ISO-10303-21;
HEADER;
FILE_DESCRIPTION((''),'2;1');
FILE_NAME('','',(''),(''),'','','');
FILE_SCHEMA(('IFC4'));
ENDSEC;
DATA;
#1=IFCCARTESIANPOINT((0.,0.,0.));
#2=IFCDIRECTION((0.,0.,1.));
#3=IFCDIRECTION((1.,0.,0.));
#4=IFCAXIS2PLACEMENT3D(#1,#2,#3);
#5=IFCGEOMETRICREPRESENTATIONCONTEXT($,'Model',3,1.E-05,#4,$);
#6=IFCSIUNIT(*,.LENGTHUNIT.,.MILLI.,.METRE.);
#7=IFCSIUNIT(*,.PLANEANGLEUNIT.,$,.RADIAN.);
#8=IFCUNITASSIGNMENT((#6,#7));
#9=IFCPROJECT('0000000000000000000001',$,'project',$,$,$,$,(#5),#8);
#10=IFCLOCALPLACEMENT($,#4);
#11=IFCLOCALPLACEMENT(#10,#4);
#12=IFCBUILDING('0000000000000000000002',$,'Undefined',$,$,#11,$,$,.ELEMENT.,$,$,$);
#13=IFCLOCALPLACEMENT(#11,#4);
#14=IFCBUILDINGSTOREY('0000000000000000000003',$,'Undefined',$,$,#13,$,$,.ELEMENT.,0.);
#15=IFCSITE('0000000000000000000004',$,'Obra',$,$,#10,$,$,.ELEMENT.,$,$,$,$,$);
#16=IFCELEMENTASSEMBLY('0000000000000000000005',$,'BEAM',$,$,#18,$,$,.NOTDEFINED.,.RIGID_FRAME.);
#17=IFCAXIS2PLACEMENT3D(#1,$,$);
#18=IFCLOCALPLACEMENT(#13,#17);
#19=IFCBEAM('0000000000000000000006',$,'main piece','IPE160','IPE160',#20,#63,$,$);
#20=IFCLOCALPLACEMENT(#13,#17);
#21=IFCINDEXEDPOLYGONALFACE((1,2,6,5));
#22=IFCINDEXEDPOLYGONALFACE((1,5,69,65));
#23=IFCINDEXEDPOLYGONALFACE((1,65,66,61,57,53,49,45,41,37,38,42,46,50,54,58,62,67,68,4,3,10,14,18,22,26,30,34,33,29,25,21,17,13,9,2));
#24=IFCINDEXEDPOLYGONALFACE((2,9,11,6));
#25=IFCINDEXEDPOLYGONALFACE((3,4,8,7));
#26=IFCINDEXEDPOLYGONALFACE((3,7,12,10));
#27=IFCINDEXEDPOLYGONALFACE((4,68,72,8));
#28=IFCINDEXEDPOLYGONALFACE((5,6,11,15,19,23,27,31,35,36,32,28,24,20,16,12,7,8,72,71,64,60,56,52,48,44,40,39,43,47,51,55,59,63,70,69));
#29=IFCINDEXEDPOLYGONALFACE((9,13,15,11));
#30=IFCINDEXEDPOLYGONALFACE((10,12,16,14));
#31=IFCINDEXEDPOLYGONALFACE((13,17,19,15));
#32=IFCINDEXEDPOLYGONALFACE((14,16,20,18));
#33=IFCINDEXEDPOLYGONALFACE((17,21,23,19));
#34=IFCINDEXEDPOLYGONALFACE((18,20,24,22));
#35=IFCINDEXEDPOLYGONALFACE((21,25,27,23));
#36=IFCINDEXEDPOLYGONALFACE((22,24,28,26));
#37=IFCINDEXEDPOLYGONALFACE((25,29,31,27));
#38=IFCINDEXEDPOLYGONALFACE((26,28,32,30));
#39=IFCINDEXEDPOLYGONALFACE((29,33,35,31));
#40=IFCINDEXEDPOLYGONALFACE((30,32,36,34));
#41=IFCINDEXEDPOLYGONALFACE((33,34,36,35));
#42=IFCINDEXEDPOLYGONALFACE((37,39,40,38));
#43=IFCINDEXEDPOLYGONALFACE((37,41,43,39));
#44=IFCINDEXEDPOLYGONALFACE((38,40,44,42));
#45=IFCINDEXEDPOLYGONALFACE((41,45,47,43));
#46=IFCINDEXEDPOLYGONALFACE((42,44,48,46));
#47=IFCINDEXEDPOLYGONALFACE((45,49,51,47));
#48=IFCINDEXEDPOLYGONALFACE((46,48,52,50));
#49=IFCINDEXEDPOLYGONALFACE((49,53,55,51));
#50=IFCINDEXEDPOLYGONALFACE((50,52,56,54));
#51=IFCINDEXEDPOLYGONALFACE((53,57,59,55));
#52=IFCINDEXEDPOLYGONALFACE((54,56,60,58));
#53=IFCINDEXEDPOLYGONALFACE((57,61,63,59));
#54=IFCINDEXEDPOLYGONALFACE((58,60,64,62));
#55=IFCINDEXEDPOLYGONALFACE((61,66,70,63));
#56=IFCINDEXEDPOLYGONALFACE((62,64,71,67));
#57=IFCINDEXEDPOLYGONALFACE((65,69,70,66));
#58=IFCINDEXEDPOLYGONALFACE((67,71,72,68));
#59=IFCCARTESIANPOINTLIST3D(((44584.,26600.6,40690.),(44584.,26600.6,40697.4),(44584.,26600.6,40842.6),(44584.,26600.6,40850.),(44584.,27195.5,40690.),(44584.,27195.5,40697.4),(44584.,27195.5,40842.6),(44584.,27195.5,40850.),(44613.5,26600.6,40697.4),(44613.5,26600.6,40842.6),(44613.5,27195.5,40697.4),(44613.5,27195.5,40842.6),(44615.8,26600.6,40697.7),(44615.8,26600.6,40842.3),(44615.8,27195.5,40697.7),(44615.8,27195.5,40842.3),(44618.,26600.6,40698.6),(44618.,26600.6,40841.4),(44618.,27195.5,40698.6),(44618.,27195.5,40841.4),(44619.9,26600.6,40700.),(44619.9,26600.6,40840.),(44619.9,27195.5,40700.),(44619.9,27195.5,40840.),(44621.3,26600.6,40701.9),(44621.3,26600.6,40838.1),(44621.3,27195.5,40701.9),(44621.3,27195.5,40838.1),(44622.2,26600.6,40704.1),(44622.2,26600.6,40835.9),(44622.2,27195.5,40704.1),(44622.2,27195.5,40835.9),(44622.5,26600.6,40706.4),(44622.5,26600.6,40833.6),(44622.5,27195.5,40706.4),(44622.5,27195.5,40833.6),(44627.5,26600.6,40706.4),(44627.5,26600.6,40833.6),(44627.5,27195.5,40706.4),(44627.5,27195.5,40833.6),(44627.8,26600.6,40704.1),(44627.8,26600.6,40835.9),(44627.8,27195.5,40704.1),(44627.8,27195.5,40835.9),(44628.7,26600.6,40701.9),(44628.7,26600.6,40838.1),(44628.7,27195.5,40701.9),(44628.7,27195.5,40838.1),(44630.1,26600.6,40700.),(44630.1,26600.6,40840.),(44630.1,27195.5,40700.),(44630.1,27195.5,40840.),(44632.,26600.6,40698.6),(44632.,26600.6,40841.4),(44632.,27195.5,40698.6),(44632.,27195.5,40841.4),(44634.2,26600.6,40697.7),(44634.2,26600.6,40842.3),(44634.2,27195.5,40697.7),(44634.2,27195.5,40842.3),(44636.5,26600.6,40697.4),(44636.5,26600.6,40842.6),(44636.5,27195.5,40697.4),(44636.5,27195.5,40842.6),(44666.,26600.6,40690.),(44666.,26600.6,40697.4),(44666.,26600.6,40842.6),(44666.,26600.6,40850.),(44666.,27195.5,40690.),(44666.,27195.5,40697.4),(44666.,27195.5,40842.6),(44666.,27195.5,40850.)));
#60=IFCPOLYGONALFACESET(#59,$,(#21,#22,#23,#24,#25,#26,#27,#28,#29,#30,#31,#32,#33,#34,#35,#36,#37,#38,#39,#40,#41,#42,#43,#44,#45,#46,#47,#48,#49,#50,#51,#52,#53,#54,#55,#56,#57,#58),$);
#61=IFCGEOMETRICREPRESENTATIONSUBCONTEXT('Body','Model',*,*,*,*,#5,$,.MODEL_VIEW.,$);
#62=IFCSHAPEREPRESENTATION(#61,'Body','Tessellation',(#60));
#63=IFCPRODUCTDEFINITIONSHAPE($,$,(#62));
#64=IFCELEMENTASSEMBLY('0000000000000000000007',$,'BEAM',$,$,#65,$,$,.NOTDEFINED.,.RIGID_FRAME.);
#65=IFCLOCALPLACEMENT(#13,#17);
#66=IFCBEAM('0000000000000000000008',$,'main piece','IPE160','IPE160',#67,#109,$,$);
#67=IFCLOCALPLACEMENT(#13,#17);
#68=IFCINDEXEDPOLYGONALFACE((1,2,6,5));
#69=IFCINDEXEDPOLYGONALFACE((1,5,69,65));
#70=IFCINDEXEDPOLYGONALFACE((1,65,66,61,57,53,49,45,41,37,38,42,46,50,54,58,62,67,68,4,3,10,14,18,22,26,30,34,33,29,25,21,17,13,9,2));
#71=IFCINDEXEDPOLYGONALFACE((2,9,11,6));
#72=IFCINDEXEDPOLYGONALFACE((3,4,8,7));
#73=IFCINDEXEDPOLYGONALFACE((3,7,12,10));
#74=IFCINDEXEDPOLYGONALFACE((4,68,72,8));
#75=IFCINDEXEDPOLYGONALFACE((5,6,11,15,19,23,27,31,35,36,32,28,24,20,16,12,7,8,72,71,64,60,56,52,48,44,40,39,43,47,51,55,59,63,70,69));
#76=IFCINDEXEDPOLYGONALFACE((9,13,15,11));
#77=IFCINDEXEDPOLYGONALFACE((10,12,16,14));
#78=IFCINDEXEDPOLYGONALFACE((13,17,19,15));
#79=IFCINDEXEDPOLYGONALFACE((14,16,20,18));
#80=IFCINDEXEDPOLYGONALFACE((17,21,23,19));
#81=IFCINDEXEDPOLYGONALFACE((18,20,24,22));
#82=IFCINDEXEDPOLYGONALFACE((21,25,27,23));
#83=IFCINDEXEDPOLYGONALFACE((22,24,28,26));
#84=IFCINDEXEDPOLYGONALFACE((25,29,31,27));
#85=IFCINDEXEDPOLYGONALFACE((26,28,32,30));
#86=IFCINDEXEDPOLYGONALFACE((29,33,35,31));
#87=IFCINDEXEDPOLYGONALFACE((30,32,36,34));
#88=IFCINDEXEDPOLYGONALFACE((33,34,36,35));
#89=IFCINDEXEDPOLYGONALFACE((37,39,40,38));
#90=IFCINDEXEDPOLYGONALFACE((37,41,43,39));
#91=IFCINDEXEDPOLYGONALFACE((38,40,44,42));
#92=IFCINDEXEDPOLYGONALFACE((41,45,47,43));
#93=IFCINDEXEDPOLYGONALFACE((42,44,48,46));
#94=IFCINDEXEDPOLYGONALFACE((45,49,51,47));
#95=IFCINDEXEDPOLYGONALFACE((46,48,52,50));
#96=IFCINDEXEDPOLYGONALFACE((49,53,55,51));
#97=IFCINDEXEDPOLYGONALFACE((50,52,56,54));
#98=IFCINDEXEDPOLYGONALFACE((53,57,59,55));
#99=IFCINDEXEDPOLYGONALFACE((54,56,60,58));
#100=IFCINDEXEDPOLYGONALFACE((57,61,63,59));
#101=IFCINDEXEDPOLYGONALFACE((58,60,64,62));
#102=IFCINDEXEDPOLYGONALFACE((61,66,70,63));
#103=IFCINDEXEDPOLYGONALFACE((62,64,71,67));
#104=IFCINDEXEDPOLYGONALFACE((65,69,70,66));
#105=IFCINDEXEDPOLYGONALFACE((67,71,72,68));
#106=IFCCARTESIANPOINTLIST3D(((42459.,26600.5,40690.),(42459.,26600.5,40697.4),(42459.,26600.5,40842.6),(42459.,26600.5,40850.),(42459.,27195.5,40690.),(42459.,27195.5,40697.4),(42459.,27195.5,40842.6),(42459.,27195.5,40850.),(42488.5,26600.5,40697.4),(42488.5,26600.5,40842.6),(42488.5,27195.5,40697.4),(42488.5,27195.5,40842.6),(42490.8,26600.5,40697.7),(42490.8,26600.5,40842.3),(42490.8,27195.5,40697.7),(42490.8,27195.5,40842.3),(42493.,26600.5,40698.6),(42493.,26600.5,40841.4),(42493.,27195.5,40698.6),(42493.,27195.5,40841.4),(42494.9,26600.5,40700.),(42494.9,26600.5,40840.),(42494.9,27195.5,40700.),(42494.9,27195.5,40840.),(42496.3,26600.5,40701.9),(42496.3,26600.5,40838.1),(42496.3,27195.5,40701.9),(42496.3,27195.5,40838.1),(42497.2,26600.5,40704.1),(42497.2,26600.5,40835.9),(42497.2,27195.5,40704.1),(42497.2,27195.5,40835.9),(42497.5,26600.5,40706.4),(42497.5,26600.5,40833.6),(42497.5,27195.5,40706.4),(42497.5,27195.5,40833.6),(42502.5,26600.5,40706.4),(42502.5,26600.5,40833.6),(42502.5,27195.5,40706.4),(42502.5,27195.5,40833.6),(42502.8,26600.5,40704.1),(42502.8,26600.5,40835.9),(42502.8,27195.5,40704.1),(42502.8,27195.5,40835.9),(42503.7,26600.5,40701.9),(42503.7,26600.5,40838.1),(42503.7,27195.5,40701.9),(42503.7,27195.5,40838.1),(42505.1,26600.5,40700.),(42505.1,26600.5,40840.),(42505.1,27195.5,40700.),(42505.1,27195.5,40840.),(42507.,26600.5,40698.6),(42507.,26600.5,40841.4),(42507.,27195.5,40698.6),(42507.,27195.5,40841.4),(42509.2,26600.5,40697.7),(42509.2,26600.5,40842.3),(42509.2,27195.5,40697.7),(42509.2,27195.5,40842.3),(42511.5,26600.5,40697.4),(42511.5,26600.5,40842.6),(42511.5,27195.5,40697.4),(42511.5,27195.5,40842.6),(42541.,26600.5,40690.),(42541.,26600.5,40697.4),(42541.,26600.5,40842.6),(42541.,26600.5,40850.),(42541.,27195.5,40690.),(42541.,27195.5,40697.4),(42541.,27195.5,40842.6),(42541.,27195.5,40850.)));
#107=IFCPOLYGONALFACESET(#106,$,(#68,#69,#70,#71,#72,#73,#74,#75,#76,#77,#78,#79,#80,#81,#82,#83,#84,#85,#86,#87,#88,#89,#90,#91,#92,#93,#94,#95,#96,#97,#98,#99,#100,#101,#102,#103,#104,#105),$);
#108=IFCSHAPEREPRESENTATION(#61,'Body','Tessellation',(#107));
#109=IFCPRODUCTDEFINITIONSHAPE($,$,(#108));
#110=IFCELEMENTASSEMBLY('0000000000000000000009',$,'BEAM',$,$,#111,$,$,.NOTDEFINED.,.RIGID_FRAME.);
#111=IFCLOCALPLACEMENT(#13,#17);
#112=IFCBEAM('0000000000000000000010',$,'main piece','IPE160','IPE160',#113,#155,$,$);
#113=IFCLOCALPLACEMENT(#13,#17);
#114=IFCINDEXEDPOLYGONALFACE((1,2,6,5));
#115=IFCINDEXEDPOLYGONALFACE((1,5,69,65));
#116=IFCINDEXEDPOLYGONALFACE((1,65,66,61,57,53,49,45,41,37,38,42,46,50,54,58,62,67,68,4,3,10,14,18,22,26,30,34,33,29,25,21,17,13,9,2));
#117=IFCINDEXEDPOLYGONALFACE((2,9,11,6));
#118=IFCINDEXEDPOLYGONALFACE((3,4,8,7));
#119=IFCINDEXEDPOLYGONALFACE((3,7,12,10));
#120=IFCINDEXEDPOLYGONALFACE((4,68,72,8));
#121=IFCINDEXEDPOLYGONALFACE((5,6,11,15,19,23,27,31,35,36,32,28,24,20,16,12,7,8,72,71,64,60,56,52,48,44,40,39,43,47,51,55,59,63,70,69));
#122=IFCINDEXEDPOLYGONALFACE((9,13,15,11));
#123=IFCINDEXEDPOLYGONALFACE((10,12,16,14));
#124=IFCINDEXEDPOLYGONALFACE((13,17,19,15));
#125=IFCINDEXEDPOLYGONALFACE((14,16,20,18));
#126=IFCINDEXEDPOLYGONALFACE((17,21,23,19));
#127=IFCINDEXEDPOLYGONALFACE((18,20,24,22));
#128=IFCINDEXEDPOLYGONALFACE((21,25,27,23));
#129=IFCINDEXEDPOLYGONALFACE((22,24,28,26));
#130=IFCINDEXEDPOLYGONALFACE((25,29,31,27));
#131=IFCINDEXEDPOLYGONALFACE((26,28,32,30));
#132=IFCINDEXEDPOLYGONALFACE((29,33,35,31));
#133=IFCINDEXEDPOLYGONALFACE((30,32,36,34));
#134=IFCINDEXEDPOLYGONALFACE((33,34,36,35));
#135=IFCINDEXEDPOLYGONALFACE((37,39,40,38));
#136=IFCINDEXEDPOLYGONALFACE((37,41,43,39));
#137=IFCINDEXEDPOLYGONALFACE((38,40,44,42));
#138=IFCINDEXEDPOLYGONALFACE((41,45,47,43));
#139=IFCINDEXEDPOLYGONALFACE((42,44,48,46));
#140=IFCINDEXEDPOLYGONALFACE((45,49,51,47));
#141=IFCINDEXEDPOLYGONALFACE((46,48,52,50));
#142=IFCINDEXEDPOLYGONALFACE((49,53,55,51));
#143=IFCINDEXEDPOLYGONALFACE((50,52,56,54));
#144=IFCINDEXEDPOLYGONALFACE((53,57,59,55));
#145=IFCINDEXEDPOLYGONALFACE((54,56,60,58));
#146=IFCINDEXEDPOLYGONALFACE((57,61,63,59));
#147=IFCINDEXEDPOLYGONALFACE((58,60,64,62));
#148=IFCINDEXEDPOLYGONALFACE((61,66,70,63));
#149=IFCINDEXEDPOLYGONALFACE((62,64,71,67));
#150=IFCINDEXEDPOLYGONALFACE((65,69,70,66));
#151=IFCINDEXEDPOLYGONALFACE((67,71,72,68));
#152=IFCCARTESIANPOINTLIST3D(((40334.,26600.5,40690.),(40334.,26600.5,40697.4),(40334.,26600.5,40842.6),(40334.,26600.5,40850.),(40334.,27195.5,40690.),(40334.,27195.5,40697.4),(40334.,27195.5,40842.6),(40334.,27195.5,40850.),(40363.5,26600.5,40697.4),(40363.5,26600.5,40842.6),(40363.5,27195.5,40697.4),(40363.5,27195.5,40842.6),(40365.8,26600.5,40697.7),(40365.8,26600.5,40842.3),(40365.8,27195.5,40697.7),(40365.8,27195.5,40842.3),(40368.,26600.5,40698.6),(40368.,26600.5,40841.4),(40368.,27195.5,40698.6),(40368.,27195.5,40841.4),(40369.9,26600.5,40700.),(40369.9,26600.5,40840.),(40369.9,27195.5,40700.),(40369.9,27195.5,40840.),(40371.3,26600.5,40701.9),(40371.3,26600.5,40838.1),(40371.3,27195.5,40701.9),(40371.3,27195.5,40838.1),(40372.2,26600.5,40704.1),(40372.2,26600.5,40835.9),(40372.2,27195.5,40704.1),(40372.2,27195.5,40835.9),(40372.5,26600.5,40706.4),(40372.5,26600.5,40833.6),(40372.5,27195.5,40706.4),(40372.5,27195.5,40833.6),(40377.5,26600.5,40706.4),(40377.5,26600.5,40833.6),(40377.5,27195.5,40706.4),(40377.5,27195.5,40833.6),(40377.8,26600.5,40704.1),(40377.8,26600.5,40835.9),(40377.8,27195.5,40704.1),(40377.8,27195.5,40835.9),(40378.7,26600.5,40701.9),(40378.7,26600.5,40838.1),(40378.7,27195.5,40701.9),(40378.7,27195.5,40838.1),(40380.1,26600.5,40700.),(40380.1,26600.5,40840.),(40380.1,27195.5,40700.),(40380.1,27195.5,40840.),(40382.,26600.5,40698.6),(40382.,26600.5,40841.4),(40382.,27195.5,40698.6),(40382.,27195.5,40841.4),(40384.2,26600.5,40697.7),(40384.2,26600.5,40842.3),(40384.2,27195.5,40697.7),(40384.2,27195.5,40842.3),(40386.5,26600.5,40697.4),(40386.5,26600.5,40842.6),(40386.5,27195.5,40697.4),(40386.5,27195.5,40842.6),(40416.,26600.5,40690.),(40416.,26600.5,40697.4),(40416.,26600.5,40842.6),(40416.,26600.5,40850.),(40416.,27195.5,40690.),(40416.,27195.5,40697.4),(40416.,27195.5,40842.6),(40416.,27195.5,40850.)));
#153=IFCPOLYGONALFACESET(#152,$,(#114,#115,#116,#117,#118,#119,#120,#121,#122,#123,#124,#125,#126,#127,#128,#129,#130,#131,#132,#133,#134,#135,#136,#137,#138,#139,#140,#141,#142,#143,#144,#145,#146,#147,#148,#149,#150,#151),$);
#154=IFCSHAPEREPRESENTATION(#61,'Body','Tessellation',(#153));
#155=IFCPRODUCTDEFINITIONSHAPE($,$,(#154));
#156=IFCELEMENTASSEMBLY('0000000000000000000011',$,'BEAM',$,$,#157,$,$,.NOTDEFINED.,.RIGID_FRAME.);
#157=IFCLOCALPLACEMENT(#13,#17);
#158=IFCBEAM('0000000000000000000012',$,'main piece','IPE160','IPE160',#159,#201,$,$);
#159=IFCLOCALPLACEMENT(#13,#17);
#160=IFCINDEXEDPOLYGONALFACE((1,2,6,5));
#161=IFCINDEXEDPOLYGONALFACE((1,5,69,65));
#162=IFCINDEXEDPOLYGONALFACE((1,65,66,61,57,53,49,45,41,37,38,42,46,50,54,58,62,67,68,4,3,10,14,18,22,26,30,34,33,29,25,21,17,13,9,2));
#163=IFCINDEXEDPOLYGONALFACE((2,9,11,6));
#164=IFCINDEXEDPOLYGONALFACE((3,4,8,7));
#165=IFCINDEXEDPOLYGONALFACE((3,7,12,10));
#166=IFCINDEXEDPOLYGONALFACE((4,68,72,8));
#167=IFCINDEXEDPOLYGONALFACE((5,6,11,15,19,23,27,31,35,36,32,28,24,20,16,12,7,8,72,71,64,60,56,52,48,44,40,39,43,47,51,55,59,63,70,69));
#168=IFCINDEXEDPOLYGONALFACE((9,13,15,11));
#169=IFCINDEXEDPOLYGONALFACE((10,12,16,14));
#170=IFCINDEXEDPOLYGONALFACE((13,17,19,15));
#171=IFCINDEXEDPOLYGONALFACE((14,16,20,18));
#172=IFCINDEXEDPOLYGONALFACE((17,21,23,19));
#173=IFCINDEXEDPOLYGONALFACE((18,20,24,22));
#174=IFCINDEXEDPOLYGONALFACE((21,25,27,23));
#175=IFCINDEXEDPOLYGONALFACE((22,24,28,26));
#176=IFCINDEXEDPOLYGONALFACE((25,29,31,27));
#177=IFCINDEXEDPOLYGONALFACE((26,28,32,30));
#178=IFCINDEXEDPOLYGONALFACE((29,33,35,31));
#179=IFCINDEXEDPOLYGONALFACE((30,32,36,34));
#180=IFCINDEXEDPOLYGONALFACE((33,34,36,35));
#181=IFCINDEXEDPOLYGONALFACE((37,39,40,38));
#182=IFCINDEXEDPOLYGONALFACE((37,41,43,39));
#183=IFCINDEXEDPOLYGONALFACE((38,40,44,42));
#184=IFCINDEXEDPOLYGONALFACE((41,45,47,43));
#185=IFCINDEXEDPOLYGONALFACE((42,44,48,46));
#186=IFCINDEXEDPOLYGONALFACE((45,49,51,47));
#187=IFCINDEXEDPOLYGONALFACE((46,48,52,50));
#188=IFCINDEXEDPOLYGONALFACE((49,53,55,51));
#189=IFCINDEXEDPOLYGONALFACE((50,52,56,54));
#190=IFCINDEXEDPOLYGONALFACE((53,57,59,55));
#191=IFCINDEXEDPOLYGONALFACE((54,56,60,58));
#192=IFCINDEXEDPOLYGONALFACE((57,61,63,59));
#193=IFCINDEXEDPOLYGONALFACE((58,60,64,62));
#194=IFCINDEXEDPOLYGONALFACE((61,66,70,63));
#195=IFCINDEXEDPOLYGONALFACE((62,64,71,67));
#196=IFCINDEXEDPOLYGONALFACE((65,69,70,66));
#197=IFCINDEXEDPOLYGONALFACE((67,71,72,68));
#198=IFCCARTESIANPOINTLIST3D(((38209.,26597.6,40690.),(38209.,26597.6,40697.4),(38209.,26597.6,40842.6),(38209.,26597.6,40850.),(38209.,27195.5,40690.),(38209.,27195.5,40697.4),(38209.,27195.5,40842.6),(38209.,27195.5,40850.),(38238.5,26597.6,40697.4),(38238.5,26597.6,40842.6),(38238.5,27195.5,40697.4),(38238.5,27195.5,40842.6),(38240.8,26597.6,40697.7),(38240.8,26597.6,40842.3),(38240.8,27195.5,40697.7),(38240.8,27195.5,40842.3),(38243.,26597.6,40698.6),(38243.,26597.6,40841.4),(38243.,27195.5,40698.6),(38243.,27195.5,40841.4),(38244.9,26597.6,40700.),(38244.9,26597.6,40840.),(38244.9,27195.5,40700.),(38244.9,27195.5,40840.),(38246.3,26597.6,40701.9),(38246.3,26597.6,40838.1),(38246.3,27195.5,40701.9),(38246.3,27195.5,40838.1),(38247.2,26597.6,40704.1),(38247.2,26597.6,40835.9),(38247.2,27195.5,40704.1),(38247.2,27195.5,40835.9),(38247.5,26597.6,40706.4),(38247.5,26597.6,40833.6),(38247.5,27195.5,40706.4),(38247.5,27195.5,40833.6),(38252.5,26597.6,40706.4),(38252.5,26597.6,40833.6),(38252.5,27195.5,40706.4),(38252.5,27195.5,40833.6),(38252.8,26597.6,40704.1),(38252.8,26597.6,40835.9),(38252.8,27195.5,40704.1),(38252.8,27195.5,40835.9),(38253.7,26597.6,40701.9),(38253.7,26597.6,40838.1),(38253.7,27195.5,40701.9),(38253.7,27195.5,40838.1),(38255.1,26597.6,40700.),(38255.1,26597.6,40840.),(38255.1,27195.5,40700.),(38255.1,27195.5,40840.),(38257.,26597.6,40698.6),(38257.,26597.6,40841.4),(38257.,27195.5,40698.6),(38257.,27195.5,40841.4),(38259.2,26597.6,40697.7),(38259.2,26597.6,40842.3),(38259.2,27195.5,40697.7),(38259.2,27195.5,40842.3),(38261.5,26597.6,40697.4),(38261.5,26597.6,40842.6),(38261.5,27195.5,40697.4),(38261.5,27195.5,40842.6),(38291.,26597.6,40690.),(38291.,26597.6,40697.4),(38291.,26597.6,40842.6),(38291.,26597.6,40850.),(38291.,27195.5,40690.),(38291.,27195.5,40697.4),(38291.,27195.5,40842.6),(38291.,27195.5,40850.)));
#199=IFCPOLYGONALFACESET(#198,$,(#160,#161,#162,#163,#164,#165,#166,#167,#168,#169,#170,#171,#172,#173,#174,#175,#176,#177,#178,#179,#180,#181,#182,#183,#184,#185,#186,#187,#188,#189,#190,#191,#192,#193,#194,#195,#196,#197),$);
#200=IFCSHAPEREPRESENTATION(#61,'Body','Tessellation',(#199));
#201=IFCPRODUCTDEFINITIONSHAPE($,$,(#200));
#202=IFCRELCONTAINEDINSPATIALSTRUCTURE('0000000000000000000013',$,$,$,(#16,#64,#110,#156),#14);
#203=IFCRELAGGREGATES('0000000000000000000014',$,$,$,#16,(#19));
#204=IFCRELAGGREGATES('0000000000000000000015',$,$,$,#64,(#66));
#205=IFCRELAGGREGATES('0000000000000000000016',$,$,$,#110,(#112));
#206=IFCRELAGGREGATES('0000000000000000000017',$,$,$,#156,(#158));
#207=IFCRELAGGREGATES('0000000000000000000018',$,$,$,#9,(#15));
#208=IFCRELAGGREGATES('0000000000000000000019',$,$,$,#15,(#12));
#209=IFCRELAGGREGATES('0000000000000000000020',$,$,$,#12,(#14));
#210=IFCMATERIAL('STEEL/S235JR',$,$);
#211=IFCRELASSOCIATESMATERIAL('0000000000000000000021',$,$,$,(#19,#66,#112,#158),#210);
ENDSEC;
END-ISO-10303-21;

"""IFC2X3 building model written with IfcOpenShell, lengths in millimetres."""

from ifc_helpers import new_model, si_unit, frame, origin_with_axes, origin_2d_with_axis, place, context, subcontext, project, spatial, i_section, extrude, material, element, aggregate, save


model = new_model("IFC2X3")

# Units and contexts
model_context = context("Model", 3, precision=1e-05, world=origin_with_axes())
body_context = subcontext(model_context, "Body", "Model", "MODEL_VIEW")
ifc_project = project(units=[si_unit("LENGTHUNIT", "METRE", prefix="MILLI"), si_unit("PLANEANGLEUNIT", "RADIAN")], contexts=[model_context])

# Site, building, storey
site_placement = place(None, origin_with_axes())
site = spatial("IfcSite", under=ifc_project, at=site_placement, Name="Obra", CompositionType="ELEMENT")
building_placement = place(site_placement, origin_with_axes())
building = spatial("IfcBuilding", under=site, at=building_placement, Name="Undefined", CompositionType="ELEMENT")
storey_placement = place(building_placement, origin_with_axes())
storey = spatial("IfcBuildingStorey", under=building, at=storey_placement, Name="Undefined", CompositionType="ELEMENT", Elevation=0.0)

# Element assemblies, beams
ifc_material_1 = material(Name="STEEL/S235JR")
assembly_1_placement = place(storey_placement, origin_with_axes())
assembly_1 = element("IfcElementAssembly", 1, at=assembly_1_placement, inside=storey, Name="BEAM", AssemblyPlace="NOTDEFINED", PredefinedType="RIGID_FRAME")
beam_1_placement = place(assembly_1_placement, frame((44625.0, 26600.6, 40770.0), z_axis=(0.0, 0.0, 1.0), x_axis=(0.0, 1.0, 0.0)))
beam_1 = element("IfcBeam", 2, at=beam_1_placement, material=ifc_material_1, Name="main piece", Description="IPE160", ObjectType="IPE160", context=body_context, shape_type="SweptSolid", body=[
    extrude(i_section(OverallWidth=82.0, OverallDepth=160.0, WebThickness=5.0, FlangeThickness=7.4, FilletRadius=9.0, at=origin_2d_with_axis()), frame((594.9, 0.0, 0.0), z_axis=(-1.0, 0.0, 0.0), x_axis=(0.0, -1.0, 0.0)), (0.0, 0.0, 1.0), 594.9),
])
aggregate(assembly_1, [beam_1])
assembly_2_placement = place(storey_placement, origin_with_axes())
assembly_2 = element("IfcElementAssembly", 3, at=assembly_2_placement, inside=storey, Name="BEAM", AssemblyPlace="NOTDEFINED", PredefinedType="RIGID_FRAME")
beam_2_placement = place(assembly_2_placement, frame((42500.0, 26600.5, 40770.0), z_axis=(0.0, 0.0, 1.0), x_axis=(0.0, 1.0, 0.0)))
beam_2 = element("IfcBeam", 4, at=beam_2_placement, material=ifc_material_1, Name="main piece", Description="IPE160", ObjectType="IPE160", context=body_context, shape_type="SweptSolid", body=[
    extrude(i_section(OverallWidth=82.0, OverallDepth=160.0, WebThickness=5.0, FlangeThickness=7.4, FilletRadius=9.0, at=origin_2d_with_axis()), frame((595.0, 0.0, 0.0), z_axis=(-1.0, 0.0, 0.0), x_axis=(0.0, -1.0, 0.0)), (0.0, 0.0, 1.0), 595.0),
])
aggregate(assembly_2, [beam_2])
assembly_3_placement = place(storey_placement, origin_with_axes())
assembly_3 = element("IfcElementAssembly", 5, at=assembly_3_placement, inside=storey, Name="BEAM", AssemblyPlace="NOTDEFINED", PredefinedType="RIGID_FRAME")
beam_3_placement = place(assembly_3_placement, frame((40375.0, 26600.5, 40770.0), z_axis=(0.0, 0.0, 1.0), x_axis=(0.0, 1.0, 0.0)))
beam_3 = element("IfcBeam", 6, at=beam_3_placement, material=ifc_material_1, Name="main piece", Description="IPE160", ObjectType="IPE160", context=body_context, shape_type="SweptSolid", body=[
    extrude(i_section(OverallWidth=82.0, OverallDepth=160.0, WebThickness=5.0, FlangeThickness=7.4, FilletRadius=9.0, at=origin_2d_with_axis()), frame((595.0, 0.0, 0.0), z_axis=(-1.0, 0.0, 0.0), x_axis=(0.0, -1.0, 0.0)), (0.0, 0.0, 1.0), 595.0),
])
aggregate(assembly_3, [beam_3])
assembly_4_placement = place(storey_placement, origin_with_axes())
assembly_4 = element("IfcElementAssembly", 7, at=assembly_4_placement, inside=storey, Name="BEAM", AssemblyPlace="NOTDEFINED", PredefinedType="RIGID_FRAME")
beam_4_placement = place(assembly_4_placement, frame((38250.0, 26597.6, 40770.0), z_axis=(0.0, 0.0, 1.0), x_axis=(0.0, 1.0, 0.0)))
beam_4 = element("IfcBeam", 8, at=beam_4_placement, material=ifc_material_1, Name="main piece", Description="IPE160", ObjectType="IPE160", context=body_context, shape_type="SweptSolid", body=[
    extrude(i_section(OverallWidth=82.0, OverallDepth=160.0, WebThickness=5.0, FlangeThickness=7.4, FilletRadius=9.0, at=origin_2d_with_axis()), frame((597.9, 0.0, 0.0), z_axis=(-1.0, 0.0, 0.0), x_axis=(0.0, -1.0, 0.0)), (0.0, 0.0, 1.0), 597.9),
])
aggregate(assembly_4, [beam_4])

save(model, "model.ifc")
